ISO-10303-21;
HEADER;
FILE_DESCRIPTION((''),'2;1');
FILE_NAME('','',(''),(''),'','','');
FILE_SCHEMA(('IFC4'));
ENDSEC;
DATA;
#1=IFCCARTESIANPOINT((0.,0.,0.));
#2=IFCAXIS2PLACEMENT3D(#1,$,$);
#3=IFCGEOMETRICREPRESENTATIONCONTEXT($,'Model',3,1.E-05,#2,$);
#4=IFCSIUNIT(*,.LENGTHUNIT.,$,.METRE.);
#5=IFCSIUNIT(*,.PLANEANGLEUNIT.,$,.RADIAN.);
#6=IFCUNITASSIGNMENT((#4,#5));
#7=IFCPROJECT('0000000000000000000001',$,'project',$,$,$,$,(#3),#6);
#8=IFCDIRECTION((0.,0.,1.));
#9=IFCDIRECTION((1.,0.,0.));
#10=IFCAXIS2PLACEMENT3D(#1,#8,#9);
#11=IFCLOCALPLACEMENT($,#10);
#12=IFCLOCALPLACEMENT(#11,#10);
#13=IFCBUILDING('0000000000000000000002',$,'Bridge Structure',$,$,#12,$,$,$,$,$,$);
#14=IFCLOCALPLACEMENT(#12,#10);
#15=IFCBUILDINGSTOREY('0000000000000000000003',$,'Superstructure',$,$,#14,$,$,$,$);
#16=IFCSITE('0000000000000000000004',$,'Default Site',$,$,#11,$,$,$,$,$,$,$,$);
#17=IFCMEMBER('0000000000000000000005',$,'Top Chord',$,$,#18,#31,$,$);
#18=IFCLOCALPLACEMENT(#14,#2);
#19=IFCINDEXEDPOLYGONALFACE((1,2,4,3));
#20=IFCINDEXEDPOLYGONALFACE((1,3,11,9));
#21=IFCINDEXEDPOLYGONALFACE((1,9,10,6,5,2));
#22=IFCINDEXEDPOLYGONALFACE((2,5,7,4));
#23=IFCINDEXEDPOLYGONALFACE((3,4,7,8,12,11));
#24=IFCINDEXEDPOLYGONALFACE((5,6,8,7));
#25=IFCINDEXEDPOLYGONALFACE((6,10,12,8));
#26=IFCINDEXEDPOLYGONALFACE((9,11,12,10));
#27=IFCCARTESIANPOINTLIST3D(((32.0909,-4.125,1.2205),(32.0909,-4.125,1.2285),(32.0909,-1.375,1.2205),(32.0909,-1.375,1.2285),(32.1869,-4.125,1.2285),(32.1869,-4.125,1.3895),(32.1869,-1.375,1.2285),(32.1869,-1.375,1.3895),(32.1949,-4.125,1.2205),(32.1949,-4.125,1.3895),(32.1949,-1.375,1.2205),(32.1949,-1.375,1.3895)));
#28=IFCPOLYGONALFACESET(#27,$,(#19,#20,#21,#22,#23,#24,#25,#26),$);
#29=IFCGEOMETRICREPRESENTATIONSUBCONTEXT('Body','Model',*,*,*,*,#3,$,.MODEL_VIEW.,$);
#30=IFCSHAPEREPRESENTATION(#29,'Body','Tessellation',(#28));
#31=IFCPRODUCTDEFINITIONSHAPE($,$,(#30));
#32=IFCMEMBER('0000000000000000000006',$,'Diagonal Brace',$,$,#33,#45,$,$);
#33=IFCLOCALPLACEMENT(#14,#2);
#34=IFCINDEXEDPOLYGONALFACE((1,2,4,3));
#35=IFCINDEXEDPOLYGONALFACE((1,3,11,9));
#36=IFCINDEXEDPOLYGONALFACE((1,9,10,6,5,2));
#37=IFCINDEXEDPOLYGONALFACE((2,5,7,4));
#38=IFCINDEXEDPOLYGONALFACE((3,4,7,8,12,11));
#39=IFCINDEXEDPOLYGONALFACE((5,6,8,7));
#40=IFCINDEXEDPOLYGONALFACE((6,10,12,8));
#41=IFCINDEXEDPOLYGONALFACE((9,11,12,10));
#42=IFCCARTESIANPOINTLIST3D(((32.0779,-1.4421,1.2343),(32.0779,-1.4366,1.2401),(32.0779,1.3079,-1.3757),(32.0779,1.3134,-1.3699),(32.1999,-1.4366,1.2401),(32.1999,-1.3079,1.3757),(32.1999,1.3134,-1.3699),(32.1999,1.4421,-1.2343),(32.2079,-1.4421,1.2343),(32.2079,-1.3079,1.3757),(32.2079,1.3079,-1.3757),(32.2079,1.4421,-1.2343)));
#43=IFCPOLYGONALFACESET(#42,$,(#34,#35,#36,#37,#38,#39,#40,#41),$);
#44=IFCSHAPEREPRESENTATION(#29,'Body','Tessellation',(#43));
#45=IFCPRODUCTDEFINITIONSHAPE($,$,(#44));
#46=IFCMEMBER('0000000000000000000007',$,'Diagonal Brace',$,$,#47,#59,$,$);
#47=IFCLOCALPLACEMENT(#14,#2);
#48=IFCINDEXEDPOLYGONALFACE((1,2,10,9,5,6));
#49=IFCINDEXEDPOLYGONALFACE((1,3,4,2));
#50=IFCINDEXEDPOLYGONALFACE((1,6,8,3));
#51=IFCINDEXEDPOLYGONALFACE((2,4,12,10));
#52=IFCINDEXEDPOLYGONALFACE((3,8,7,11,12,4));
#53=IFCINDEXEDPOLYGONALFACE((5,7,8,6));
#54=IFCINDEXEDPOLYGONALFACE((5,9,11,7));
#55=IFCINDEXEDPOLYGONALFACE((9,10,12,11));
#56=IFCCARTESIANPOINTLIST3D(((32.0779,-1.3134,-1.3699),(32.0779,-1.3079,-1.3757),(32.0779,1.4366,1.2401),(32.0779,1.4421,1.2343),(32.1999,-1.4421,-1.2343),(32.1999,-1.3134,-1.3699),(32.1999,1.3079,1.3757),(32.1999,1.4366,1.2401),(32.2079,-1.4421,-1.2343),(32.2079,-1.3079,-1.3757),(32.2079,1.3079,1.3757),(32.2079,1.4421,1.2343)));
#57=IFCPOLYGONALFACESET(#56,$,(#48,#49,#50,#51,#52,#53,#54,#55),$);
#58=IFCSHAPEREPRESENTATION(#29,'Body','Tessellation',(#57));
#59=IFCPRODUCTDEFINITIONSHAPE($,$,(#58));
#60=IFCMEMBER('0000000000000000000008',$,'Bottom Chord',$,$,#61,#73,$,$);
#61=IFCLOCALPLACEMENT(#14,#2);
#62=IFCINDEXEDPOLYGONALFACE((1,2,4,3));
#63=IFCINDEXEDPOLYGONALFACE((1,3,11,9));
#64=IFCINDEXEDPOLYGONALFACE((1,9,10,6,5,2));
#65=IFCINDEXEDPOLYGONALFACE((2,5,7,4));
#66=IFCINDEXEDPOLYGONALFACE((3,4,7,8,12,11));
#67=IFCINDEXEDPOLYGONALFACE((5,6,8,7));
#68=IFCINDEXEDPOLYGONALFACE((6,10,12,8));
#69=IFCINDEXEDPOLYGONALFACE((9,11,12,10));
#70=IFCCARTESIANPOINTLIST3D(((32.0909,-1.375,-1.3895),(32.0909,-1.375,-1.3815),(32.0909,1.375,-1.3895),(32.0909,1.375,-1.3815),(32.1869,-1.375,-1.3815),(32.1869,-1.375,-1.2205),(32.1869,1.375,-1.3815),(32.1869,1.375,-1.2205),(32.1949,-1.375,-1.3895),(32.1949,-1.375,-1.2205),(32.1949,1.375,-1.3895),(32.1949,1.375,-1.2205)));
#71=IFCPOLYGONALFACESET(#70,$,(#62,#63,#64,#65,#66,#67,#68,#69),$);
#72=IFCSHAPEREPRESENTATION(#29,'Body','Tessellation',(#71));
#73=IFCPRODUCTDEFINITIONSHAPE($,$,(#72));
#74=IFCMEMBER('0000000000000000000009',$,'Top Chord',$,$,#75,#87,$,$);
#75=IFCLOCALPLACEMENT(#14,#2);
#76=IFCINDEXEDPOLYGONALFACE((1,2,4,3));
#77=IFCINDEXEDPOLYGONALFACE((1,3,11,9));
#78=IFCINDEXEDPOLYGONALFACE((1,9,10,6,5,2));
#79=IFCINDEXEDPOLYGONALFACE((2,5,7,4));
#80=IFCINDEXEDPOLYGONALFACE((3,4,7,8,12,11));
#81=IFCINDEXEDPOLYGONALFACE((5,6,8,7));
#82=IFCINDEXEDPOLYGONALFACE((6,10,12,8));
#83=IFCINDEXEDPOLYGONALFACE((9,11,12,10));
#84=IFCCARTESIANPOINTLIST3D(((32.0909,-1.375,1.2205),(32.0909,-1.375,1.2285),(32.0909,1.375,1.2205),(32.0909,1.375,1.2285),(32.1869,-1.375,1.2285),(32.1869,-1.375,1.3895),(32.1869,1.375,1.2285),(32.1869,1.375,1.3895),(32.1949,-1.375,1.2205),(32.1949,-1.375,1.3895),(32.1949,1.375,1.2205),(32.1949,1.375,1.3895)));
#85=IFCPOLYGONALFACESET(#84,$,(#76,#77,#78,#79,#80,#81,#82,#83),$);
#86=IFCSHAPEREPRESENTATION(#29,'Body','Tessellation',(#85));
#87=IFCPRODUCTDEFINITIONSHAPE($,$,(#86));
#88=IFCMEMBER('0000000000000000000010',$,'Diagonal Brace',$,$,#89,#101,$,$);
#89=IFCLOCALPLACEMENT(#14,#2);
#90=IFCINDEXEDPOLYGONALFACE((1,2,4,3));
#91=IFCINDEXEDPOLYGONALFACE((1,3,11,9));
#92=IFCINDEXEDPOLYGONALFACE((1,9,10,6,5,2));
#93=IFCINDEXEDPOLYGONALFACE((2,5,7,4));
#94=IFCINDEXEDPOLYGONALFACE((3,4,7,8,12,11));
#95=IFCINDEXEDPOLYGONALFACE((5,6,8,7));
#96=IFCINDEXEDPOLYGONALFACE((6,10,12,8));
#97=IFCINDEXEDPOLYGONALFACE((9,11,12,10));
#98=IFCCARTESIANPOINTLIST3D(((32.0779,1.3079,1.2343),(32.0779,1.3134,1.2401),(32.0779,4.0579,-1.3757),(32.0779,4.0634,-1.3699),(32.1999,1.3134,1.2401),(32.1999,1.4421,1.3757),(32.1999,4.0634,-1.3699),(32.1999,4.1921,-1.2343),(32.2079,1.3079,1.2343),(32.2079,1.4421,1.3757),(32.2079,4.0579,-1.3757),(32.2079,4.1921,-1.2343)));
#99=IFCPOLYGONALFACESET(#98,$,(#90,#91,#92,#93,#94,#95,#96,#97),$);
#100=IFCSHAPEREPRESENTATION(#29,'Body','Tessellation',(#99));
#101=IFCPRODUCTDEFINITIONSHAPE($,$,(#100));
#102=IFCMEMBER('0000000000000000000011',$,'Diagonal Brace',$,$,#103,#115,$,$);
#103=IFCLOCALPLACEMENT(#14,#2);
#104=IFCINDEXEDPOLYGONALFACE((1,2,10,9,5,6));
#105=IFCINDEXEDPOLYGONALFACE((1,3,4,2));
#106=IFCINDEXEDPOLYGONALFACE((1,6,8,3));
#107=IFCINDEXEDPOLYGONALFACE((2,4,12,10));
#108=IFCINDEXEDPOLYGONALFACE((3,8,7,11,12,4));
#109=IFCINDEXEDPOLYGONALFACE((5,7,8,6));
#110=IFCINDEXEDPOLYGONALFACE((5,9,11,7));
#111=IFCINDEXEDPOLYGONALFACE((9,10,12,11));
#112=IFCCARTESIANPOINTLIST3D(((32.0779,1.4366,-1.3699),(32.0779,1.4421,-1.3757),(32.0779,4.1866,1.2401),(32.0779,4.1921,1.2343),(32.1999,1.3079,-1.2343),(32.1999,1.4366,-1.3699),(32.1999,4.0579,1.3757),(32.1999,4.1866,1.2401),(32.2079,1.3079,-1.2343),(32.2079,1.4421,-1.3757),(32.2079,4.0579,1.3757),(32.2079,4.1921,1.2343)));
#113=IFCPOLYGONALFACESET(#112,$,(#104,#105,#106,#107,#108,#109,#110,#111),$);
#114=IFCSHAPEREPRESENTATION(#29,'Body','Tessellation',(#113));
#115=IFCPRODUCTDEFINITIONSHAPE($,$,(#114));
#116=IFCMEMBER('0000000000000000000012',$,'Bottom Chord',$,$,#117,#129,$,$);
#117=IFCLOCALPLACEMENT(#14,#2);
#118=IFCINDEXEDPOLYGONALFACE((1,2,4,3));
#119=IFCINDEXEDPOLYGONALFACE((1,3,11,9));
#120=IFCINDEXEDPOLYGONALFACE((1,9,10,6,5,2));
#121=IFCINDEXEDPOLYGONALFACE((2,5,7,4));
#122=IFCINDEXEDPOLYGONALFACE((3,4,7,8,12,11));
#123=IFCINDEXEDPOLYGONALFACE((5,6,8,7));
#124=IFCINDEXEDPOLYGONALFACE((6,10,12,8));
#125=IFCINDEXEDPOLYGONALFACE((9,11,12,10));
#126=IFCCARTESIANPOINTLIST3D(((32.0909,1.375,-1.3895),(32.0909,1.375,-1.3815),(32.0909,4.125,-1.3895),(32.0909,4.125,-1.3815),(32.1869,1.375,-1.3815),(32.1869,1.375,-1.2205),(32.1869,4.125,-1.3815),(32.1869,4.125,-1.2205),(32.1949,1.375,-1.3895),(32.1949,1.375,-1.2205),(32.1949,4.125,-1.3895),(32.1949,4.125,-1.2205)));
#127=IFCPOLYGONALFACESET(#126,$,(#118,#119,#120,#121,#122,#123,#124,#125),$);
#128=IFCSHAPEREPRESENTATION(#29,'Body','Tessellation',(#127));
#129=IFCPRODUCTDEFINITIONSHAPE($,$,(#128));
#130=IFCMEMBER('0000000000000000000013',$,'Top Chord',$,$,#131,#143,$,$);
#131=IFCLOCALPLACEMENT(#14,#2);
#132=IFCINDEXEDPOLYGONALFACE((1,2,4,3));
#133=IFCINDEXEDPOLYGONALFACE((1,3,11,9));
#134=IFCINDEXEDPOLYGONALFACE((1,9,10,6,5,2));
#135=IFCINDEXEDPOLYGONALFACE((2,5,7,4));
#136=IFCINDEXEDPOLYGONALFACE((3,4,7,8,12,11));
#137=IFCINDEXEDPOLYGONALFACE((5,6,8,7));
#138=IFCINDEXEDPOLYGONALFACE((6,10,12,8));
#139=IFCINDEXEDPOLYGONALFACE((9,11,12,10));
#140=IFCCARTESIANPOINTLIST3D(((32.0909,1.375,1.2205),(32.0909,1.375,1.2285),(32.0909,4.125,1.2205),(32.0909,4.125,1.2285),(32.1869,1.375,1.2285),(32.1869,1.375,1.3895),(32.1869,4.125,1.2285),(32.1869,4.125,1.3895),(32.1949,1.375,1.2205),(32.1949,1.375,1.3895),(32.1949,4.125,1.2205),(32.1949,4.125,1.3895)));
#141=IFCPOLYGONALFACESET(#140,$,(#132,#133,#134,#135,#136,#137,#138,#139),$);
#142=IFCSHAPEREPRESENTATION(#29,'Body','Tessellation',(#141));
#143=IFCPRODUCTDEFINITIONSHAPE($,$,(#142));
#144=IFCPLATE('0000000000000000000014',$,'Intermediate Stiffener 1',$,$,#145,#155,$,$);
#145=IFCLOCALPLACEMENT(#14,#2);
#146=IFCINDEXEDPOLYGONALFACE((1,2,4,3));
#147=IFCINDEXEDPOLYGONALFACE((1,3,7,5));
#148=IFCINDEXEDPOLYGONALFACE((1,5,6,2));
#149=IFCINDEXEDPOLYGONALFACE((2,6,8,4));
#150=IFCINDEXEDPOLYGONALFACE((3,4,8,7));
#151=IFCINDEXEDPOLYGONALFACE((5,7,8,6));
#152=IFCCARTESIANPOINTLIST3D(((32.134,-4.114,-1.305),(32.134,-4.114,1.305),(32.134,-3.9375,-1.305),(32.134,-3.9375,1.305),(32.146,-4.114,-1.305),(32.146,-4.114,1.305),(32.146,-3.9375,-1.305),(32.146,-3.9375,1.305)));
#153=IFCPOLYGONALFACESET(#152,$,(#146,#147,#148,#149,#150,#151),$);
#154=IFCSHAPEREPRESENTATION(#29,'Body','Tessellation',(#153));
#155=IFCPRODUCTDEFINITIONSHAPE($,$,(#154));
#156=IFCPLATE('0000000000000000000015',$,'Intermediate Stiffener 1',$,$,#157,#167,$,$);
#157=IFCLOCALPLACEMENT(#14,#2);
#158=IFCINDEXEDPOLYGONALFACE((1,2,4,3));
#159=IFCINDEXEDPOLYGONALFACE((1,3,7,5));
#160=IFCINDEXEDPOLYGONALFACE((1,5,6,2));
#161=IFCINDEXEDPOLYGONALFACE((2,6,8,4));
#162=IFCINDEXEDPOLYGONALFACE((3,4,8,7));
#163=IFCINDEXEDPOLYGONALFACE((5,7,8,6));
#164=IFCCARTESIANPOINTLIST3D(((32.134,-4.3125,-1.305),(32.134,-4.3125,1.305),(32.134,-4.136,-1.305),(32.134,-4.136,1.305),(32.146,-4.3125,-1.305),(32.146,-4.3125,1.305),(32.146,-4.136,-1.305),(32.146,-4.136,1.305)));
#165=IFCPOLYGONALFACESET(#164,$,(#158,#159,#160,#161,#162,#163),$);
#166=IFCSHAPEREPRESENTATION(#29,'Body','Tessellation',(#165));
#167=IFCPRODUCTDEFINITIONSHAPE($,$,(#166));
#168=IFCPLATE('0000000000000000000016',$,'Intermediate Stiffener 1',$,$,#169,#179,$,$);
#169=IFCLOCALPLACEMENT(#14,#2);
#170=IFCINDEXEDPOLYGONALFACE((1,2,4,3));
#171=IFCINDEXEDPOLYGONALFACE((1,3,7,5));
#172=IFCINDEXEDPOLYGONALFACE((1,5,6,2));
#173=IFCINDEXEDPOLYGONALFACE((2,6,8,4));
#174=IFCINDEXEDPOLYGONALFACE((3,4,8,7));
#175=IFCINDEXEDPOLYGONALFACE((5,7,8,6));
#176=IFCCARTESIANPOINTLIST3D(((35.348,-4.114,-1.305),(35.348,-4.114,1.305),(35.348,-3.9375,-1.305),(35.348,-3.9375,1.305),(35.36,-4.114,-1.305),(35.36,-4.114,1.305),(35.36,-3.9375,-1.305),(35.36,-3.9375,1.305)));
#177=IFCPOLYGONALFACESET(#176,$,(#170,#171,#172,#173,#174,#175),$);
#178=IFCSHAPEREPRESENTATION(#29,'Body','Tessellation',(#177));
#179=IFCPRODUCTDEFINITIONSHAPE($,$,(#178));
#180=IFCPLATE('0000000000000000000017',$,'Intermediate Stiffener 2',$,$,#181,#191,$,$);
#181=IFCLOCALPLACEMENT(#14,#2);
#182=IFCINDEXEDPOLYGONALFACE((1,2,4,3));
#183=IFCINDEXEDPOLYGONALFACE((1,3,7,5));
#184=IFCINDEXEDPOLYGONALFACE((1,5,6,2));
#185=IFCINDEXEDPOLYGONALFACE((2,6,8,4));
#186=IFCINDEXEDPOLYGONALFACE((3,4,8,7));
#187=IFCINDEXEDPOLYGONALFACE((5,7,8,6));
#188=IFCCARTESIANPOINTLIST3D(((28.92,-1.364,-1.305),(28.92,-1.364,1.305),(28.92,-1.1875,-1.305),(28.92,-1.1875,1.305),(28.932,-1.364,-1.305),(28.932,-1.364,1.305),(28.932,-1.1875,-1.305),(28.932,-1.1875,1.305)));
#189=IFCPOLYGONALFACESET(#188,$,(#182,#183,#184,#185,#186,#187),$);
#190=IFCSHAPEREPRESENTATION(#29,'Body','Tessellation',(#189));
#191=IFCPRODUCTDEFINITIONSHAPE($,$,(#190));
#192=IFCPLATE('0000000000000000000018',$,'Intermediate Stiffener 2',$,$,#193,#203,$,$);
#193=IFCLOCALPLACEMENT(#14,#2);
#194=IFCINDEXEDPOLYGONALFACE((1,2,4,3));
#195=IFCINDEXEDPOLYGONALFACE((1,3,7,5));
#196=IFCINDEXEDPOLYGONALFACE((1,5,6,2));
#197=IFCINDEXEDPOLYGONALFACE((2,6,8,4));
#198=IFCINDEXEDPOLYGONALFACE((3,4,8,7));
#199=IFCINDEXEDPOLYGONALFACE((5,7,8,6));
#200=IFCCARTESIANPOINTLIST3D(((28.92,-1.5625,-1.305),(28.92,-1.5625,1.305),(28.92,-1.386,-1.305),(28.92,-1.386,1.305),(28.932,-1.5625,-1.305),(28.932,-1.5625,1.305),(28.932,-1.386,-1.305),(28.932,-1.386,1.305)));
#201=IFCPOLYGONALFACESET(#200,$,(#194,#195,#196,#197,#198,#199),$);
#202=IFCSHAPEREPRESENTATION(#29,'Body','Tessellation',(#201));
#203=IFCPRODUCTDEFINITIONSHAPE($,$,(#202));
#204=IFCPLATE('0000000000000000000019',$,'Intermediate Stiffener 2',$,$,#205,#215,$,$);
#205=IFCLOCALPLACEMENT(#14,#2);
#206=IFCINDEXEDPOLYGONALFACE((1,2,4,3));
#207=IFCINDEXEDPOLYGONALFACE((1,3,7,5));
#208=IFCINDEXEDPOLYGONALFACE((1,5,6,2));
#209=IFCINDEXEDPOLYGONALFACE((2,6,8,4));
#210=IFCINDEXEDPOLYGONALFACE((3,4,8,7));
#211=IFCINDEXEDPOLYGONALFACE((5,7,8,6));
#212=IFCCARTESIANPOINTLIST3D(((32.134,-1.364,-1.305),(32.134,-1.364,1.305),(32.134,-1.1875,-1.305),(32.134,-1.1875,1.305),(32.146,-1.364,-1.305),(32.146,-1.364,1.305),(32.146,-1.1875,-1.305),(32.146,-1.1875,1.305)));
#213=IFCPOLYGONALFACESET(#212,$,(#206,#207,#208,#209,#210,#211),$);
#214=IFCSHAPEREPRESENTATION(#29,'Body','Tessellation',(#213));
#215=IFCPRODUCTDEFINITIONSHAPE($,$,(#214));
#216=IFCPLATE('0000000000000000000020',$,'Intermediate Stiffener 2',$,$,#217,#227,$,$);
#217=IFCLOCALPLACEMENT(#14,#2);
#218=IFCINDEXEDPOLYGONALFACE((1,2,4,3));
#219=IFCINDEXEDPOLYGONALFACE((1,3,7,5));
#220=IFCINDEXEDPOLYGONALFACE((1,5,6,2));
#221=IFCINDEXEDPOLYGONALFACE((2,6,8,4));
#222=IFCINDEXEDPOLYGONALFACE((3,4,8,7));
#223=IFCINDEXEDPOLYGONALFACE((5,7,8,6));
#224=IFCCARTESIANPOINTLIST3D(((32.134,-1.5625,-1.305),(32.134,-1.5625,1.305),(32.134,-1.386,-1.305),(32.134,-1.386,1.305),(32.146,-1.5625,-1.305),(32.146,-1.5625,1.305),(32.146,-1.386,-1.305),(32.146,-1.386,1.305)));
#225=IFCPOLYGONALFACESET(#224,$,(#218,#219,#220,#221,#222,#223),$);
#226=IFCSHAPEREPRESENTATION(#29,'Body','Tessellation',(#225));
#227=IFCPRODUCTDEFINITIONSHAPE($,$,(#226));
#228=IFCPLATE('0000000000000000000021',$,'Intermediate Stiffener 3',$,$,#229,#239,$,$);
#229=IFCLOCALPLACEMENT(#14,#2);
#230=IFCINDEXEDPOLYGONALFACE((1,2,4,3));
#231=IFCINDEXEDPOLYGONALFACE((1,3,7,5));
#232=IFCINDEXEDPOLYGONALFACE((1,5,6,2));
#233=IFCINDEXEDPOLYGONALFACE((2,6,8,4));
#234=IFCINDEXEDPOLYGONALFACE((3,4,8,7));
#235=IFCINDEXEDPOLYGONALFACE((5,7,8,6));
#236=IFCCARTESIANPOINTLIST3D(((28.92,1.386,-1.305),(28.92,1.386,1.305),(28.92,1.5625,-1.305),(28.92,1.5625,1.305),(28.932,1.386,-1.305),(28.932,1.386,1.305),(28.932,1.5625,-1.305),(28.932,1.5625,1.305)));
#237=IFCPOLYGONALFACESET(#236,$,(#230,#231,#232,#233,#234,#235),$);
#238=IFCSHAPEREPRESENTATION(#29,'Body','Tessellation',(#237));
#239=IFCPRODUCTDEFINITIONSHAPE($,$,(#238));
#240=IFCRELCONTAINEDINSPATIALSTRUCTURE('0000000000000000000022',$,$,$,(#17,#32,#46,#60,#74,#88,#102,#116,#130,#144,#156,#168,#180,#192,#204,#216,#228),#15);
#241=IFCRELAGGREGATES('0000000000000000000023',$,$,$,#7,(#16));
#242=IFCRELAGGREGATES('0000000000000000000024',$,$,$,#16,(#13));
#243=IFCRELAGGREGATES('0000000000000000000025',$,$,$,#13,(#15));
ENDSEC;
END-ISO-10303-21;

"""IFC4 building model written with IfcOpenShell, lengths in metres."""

from ifc_helpers import new_model, si_unit, frame, origin, origin_with_axes, origin_2d_with_axis, place, context, subcontext, project, spatial, rectangle, l_section, extrude, element, save


model = new_model("IFC4")

# Units and contexts
model_context = context("Model", 3, precision=1e-05, world=origin())
body_context = subcontext(model_context, "Body", "Model", "MODEL_VIEW")
ifc_project = project(units=[si_unit("LENGTHUNIT", "METRE"), si_unit("PLANEANGLEUNIT", "RADIAN")], contexts=[model_context])

# Site, building, storey
site_placement = place(None, origin_with_axes())
site = spatial("IfcSite", under=ifc_project, at=site_placement, Name="Default Site")
building_placement = place(site_placement, origin_with_axes())
building = spatial("IfcBuilding", under=site, at=building_placement, Name="Bridge Structure")
storey_placement = place(building_placement, origin_with_axes())
storey = spatial("IfcBuildingStorey", under=building, at=storey_placement, Name="Superstructure")

# Members
for number, where, z_axis, x_axis, name in (
    (1, (32.1429, -4.125, 1.305), (0.0, 1.0, 0.0), (-1.0, 0.0, 0.0), "Top Chord"),
):
    element("IfcMember", number, at=place(storey_placement, frame(where, z_axis=z_axis, x_axis=x_axis)), inside=storey, Name=name, context=body_context, shape_type="SweptSolid", body=[
        extrude(l_section(Depth=0.169, Width=0.104, Thickness=0.008, at=origin_2d_with_axis()), origin_with_axes(), (0.0, 0.0, 1.0), 2.75),
    ])
for number, where, z_axis, x_axis, name in (
    (2, (32.1429, -1.375, 1.305), (0.0, 0.725329, -0.688403), (-1.0, 0.0, 0.0), "Diagonal Brace"),
    (3, (32.1429, -1.375, -1.305), (0.0, 0.725329, 0.688403), (-1.0, 0.0, 0.0), "Diagonal Brace"),
):
    element("IfcMember", number, at=place(storey_placement, frame(where, z_axis=z_axis, x_axis=x_axis)), inside=storey, Name=name, context=body_context, shape_type="SweptSolid", body=[
        extrude(l_section(Depth=0.195, Width=0.13, Thickness=0.008, at=origin_2d_with_axis()), origin_with_axes(), (0.0, 0.0, 1.0), 3.7914),
    ])
for number, where, z_axis, x_axis, name in (
    (4, (32.1429, -1.375, -1.305), (0.0, 1.0, 0.0), (-1.0, 0.0, 0.0), "Bottom Chord"),
    (5, (32.1429, -1.375, 1.305), (0.0, 1.0, 0.0), (-1.0, 0.0, 0.0), "Top Chord"),
):
    element("IfcMember", number, at=place(storey_placement, frame(where, z_axis=z_axis, x_axis=x_axis)), inside=storey, Name=name, context=body_context, shape_type="SweptSolid", body=[
        extrude(l_section(Depth=0.169, Width=0.104, Thickness=0.008, at=origin_2d_with_axis()), origin_with_axes(), (0.0, 0.0, 1.0), 2.75),
    ])
for number, where, z_axis, x_axis, name in (
    (6, (32.1429, 1.375, 1.305), (0.0, 0.725329, -0.688403), (-1.0, 0.0, 0.0), "Diagonal Brace"),
    (7, (32.1429, 1.375, -1.305), (0.0, 0.725329, 0.688403), (-1.0, 0.0, 0.0), "Diagonal Brace"),
):
    element("IfcMember", number, at=place(storey_placement, frame(where, z_axis=z_axis, x_axis=x_axis)), inside=storey, Name=name, context=body_context, shape_type="SweptSolid", body=[
        extrude(l_section(Depth=0.195, Width=0.13, Thickness=0.008, at=origin_2d_with_axis()), origin_with_axes(), (0.0, 0.0, 1.0), 3.7914),
    ])
for number, where, z_axis, x_axis, name in (
    (8, (32.1429, 1.375, -1.305), (0.0, 1.0, 0.0), (-1.0, 0.0, 0.0), "Bottom Chord"),
    (9, (32.1429, 1.375, 1.305), (0.0, 1.0, 0.0), (-1.0, 0.0, 0.0), "Top Chord"),
):
    element("IfcMember", number, at=place(storey_placement, frame(where, z_axis=z_axis, x_axis=x_axis)), inside=storey, Name=name, context=body_context, shape_type="SweptSolid", body=[
        extrude(l_section(Depth=0.169, Width=0.104, Thickness=0.008, at=origin_2d_with_axis()), origin_with_axes(), (0.0, 0.0, 1.0), 2.75),
    ])

# Plates
for number, where, z_axis, x_axis, name in (
    (10, (32.14, -4.0258, -1.305), (0.0, 0.0, 1.0), (1.0, 0.0, 0.0), "Intermediate Stiffener 1"),
    (11, (32.14, -4.2243, -1.305), (0.0, 0.0, 1.0), (1.0, 0.0, 0.0), "Intermediate Stiffener 1"),
    (12, (35.354, -4.0258, -1.305), (0.0, 0.0, 1.0), (1.0, 0.0, 0.0), "Intermediate Stiffener 1"),
    (13, (28.926, -1.2757, -1.305), (0.0, 0.0, 1.0), (1.0, 0.0, 0.0), "Intermediate Stiffener 2"),
    (14, (28.926, -1.4743, -1.305), (0.0, 0.0, 1.0), (1.0, 0.0, 0.0), "Intermediate Stiffener 2"),
    (15, (32.14, -1.2757, -1.305), (0.0, 0.0, 1.0), (1.0, 0.0, 0.0), "Intermediate Stiffener 2"),
    (16, (32.14, -1.4743, -1.305), (0.0, 0.0, 1.0), (1.0, 0.0, 0.0), "Intermediate Stiffener 2"),
    (17, (28.926, 1.4743, -1.305), (0.0, 0.0, 1.0), (1.0, 0.0, 0.0), "Intermediate Stiffener 3"),
):
    element("IfcPlate", number, at=place(storey_placement, frame(where, z_axis=z_axis, x_axis=x_axis)), inside=storey, Name=name, context=body_context, shape_type="SweptSolid", body=[
        extrude(rectangle(XDim=0.012, YDim=0.1765, at=origin_2d_with_axis()), origin_with_axes(), (0.0, 0.0, 1.0), 2.61),
    ])

save(model, "model.ifc")
